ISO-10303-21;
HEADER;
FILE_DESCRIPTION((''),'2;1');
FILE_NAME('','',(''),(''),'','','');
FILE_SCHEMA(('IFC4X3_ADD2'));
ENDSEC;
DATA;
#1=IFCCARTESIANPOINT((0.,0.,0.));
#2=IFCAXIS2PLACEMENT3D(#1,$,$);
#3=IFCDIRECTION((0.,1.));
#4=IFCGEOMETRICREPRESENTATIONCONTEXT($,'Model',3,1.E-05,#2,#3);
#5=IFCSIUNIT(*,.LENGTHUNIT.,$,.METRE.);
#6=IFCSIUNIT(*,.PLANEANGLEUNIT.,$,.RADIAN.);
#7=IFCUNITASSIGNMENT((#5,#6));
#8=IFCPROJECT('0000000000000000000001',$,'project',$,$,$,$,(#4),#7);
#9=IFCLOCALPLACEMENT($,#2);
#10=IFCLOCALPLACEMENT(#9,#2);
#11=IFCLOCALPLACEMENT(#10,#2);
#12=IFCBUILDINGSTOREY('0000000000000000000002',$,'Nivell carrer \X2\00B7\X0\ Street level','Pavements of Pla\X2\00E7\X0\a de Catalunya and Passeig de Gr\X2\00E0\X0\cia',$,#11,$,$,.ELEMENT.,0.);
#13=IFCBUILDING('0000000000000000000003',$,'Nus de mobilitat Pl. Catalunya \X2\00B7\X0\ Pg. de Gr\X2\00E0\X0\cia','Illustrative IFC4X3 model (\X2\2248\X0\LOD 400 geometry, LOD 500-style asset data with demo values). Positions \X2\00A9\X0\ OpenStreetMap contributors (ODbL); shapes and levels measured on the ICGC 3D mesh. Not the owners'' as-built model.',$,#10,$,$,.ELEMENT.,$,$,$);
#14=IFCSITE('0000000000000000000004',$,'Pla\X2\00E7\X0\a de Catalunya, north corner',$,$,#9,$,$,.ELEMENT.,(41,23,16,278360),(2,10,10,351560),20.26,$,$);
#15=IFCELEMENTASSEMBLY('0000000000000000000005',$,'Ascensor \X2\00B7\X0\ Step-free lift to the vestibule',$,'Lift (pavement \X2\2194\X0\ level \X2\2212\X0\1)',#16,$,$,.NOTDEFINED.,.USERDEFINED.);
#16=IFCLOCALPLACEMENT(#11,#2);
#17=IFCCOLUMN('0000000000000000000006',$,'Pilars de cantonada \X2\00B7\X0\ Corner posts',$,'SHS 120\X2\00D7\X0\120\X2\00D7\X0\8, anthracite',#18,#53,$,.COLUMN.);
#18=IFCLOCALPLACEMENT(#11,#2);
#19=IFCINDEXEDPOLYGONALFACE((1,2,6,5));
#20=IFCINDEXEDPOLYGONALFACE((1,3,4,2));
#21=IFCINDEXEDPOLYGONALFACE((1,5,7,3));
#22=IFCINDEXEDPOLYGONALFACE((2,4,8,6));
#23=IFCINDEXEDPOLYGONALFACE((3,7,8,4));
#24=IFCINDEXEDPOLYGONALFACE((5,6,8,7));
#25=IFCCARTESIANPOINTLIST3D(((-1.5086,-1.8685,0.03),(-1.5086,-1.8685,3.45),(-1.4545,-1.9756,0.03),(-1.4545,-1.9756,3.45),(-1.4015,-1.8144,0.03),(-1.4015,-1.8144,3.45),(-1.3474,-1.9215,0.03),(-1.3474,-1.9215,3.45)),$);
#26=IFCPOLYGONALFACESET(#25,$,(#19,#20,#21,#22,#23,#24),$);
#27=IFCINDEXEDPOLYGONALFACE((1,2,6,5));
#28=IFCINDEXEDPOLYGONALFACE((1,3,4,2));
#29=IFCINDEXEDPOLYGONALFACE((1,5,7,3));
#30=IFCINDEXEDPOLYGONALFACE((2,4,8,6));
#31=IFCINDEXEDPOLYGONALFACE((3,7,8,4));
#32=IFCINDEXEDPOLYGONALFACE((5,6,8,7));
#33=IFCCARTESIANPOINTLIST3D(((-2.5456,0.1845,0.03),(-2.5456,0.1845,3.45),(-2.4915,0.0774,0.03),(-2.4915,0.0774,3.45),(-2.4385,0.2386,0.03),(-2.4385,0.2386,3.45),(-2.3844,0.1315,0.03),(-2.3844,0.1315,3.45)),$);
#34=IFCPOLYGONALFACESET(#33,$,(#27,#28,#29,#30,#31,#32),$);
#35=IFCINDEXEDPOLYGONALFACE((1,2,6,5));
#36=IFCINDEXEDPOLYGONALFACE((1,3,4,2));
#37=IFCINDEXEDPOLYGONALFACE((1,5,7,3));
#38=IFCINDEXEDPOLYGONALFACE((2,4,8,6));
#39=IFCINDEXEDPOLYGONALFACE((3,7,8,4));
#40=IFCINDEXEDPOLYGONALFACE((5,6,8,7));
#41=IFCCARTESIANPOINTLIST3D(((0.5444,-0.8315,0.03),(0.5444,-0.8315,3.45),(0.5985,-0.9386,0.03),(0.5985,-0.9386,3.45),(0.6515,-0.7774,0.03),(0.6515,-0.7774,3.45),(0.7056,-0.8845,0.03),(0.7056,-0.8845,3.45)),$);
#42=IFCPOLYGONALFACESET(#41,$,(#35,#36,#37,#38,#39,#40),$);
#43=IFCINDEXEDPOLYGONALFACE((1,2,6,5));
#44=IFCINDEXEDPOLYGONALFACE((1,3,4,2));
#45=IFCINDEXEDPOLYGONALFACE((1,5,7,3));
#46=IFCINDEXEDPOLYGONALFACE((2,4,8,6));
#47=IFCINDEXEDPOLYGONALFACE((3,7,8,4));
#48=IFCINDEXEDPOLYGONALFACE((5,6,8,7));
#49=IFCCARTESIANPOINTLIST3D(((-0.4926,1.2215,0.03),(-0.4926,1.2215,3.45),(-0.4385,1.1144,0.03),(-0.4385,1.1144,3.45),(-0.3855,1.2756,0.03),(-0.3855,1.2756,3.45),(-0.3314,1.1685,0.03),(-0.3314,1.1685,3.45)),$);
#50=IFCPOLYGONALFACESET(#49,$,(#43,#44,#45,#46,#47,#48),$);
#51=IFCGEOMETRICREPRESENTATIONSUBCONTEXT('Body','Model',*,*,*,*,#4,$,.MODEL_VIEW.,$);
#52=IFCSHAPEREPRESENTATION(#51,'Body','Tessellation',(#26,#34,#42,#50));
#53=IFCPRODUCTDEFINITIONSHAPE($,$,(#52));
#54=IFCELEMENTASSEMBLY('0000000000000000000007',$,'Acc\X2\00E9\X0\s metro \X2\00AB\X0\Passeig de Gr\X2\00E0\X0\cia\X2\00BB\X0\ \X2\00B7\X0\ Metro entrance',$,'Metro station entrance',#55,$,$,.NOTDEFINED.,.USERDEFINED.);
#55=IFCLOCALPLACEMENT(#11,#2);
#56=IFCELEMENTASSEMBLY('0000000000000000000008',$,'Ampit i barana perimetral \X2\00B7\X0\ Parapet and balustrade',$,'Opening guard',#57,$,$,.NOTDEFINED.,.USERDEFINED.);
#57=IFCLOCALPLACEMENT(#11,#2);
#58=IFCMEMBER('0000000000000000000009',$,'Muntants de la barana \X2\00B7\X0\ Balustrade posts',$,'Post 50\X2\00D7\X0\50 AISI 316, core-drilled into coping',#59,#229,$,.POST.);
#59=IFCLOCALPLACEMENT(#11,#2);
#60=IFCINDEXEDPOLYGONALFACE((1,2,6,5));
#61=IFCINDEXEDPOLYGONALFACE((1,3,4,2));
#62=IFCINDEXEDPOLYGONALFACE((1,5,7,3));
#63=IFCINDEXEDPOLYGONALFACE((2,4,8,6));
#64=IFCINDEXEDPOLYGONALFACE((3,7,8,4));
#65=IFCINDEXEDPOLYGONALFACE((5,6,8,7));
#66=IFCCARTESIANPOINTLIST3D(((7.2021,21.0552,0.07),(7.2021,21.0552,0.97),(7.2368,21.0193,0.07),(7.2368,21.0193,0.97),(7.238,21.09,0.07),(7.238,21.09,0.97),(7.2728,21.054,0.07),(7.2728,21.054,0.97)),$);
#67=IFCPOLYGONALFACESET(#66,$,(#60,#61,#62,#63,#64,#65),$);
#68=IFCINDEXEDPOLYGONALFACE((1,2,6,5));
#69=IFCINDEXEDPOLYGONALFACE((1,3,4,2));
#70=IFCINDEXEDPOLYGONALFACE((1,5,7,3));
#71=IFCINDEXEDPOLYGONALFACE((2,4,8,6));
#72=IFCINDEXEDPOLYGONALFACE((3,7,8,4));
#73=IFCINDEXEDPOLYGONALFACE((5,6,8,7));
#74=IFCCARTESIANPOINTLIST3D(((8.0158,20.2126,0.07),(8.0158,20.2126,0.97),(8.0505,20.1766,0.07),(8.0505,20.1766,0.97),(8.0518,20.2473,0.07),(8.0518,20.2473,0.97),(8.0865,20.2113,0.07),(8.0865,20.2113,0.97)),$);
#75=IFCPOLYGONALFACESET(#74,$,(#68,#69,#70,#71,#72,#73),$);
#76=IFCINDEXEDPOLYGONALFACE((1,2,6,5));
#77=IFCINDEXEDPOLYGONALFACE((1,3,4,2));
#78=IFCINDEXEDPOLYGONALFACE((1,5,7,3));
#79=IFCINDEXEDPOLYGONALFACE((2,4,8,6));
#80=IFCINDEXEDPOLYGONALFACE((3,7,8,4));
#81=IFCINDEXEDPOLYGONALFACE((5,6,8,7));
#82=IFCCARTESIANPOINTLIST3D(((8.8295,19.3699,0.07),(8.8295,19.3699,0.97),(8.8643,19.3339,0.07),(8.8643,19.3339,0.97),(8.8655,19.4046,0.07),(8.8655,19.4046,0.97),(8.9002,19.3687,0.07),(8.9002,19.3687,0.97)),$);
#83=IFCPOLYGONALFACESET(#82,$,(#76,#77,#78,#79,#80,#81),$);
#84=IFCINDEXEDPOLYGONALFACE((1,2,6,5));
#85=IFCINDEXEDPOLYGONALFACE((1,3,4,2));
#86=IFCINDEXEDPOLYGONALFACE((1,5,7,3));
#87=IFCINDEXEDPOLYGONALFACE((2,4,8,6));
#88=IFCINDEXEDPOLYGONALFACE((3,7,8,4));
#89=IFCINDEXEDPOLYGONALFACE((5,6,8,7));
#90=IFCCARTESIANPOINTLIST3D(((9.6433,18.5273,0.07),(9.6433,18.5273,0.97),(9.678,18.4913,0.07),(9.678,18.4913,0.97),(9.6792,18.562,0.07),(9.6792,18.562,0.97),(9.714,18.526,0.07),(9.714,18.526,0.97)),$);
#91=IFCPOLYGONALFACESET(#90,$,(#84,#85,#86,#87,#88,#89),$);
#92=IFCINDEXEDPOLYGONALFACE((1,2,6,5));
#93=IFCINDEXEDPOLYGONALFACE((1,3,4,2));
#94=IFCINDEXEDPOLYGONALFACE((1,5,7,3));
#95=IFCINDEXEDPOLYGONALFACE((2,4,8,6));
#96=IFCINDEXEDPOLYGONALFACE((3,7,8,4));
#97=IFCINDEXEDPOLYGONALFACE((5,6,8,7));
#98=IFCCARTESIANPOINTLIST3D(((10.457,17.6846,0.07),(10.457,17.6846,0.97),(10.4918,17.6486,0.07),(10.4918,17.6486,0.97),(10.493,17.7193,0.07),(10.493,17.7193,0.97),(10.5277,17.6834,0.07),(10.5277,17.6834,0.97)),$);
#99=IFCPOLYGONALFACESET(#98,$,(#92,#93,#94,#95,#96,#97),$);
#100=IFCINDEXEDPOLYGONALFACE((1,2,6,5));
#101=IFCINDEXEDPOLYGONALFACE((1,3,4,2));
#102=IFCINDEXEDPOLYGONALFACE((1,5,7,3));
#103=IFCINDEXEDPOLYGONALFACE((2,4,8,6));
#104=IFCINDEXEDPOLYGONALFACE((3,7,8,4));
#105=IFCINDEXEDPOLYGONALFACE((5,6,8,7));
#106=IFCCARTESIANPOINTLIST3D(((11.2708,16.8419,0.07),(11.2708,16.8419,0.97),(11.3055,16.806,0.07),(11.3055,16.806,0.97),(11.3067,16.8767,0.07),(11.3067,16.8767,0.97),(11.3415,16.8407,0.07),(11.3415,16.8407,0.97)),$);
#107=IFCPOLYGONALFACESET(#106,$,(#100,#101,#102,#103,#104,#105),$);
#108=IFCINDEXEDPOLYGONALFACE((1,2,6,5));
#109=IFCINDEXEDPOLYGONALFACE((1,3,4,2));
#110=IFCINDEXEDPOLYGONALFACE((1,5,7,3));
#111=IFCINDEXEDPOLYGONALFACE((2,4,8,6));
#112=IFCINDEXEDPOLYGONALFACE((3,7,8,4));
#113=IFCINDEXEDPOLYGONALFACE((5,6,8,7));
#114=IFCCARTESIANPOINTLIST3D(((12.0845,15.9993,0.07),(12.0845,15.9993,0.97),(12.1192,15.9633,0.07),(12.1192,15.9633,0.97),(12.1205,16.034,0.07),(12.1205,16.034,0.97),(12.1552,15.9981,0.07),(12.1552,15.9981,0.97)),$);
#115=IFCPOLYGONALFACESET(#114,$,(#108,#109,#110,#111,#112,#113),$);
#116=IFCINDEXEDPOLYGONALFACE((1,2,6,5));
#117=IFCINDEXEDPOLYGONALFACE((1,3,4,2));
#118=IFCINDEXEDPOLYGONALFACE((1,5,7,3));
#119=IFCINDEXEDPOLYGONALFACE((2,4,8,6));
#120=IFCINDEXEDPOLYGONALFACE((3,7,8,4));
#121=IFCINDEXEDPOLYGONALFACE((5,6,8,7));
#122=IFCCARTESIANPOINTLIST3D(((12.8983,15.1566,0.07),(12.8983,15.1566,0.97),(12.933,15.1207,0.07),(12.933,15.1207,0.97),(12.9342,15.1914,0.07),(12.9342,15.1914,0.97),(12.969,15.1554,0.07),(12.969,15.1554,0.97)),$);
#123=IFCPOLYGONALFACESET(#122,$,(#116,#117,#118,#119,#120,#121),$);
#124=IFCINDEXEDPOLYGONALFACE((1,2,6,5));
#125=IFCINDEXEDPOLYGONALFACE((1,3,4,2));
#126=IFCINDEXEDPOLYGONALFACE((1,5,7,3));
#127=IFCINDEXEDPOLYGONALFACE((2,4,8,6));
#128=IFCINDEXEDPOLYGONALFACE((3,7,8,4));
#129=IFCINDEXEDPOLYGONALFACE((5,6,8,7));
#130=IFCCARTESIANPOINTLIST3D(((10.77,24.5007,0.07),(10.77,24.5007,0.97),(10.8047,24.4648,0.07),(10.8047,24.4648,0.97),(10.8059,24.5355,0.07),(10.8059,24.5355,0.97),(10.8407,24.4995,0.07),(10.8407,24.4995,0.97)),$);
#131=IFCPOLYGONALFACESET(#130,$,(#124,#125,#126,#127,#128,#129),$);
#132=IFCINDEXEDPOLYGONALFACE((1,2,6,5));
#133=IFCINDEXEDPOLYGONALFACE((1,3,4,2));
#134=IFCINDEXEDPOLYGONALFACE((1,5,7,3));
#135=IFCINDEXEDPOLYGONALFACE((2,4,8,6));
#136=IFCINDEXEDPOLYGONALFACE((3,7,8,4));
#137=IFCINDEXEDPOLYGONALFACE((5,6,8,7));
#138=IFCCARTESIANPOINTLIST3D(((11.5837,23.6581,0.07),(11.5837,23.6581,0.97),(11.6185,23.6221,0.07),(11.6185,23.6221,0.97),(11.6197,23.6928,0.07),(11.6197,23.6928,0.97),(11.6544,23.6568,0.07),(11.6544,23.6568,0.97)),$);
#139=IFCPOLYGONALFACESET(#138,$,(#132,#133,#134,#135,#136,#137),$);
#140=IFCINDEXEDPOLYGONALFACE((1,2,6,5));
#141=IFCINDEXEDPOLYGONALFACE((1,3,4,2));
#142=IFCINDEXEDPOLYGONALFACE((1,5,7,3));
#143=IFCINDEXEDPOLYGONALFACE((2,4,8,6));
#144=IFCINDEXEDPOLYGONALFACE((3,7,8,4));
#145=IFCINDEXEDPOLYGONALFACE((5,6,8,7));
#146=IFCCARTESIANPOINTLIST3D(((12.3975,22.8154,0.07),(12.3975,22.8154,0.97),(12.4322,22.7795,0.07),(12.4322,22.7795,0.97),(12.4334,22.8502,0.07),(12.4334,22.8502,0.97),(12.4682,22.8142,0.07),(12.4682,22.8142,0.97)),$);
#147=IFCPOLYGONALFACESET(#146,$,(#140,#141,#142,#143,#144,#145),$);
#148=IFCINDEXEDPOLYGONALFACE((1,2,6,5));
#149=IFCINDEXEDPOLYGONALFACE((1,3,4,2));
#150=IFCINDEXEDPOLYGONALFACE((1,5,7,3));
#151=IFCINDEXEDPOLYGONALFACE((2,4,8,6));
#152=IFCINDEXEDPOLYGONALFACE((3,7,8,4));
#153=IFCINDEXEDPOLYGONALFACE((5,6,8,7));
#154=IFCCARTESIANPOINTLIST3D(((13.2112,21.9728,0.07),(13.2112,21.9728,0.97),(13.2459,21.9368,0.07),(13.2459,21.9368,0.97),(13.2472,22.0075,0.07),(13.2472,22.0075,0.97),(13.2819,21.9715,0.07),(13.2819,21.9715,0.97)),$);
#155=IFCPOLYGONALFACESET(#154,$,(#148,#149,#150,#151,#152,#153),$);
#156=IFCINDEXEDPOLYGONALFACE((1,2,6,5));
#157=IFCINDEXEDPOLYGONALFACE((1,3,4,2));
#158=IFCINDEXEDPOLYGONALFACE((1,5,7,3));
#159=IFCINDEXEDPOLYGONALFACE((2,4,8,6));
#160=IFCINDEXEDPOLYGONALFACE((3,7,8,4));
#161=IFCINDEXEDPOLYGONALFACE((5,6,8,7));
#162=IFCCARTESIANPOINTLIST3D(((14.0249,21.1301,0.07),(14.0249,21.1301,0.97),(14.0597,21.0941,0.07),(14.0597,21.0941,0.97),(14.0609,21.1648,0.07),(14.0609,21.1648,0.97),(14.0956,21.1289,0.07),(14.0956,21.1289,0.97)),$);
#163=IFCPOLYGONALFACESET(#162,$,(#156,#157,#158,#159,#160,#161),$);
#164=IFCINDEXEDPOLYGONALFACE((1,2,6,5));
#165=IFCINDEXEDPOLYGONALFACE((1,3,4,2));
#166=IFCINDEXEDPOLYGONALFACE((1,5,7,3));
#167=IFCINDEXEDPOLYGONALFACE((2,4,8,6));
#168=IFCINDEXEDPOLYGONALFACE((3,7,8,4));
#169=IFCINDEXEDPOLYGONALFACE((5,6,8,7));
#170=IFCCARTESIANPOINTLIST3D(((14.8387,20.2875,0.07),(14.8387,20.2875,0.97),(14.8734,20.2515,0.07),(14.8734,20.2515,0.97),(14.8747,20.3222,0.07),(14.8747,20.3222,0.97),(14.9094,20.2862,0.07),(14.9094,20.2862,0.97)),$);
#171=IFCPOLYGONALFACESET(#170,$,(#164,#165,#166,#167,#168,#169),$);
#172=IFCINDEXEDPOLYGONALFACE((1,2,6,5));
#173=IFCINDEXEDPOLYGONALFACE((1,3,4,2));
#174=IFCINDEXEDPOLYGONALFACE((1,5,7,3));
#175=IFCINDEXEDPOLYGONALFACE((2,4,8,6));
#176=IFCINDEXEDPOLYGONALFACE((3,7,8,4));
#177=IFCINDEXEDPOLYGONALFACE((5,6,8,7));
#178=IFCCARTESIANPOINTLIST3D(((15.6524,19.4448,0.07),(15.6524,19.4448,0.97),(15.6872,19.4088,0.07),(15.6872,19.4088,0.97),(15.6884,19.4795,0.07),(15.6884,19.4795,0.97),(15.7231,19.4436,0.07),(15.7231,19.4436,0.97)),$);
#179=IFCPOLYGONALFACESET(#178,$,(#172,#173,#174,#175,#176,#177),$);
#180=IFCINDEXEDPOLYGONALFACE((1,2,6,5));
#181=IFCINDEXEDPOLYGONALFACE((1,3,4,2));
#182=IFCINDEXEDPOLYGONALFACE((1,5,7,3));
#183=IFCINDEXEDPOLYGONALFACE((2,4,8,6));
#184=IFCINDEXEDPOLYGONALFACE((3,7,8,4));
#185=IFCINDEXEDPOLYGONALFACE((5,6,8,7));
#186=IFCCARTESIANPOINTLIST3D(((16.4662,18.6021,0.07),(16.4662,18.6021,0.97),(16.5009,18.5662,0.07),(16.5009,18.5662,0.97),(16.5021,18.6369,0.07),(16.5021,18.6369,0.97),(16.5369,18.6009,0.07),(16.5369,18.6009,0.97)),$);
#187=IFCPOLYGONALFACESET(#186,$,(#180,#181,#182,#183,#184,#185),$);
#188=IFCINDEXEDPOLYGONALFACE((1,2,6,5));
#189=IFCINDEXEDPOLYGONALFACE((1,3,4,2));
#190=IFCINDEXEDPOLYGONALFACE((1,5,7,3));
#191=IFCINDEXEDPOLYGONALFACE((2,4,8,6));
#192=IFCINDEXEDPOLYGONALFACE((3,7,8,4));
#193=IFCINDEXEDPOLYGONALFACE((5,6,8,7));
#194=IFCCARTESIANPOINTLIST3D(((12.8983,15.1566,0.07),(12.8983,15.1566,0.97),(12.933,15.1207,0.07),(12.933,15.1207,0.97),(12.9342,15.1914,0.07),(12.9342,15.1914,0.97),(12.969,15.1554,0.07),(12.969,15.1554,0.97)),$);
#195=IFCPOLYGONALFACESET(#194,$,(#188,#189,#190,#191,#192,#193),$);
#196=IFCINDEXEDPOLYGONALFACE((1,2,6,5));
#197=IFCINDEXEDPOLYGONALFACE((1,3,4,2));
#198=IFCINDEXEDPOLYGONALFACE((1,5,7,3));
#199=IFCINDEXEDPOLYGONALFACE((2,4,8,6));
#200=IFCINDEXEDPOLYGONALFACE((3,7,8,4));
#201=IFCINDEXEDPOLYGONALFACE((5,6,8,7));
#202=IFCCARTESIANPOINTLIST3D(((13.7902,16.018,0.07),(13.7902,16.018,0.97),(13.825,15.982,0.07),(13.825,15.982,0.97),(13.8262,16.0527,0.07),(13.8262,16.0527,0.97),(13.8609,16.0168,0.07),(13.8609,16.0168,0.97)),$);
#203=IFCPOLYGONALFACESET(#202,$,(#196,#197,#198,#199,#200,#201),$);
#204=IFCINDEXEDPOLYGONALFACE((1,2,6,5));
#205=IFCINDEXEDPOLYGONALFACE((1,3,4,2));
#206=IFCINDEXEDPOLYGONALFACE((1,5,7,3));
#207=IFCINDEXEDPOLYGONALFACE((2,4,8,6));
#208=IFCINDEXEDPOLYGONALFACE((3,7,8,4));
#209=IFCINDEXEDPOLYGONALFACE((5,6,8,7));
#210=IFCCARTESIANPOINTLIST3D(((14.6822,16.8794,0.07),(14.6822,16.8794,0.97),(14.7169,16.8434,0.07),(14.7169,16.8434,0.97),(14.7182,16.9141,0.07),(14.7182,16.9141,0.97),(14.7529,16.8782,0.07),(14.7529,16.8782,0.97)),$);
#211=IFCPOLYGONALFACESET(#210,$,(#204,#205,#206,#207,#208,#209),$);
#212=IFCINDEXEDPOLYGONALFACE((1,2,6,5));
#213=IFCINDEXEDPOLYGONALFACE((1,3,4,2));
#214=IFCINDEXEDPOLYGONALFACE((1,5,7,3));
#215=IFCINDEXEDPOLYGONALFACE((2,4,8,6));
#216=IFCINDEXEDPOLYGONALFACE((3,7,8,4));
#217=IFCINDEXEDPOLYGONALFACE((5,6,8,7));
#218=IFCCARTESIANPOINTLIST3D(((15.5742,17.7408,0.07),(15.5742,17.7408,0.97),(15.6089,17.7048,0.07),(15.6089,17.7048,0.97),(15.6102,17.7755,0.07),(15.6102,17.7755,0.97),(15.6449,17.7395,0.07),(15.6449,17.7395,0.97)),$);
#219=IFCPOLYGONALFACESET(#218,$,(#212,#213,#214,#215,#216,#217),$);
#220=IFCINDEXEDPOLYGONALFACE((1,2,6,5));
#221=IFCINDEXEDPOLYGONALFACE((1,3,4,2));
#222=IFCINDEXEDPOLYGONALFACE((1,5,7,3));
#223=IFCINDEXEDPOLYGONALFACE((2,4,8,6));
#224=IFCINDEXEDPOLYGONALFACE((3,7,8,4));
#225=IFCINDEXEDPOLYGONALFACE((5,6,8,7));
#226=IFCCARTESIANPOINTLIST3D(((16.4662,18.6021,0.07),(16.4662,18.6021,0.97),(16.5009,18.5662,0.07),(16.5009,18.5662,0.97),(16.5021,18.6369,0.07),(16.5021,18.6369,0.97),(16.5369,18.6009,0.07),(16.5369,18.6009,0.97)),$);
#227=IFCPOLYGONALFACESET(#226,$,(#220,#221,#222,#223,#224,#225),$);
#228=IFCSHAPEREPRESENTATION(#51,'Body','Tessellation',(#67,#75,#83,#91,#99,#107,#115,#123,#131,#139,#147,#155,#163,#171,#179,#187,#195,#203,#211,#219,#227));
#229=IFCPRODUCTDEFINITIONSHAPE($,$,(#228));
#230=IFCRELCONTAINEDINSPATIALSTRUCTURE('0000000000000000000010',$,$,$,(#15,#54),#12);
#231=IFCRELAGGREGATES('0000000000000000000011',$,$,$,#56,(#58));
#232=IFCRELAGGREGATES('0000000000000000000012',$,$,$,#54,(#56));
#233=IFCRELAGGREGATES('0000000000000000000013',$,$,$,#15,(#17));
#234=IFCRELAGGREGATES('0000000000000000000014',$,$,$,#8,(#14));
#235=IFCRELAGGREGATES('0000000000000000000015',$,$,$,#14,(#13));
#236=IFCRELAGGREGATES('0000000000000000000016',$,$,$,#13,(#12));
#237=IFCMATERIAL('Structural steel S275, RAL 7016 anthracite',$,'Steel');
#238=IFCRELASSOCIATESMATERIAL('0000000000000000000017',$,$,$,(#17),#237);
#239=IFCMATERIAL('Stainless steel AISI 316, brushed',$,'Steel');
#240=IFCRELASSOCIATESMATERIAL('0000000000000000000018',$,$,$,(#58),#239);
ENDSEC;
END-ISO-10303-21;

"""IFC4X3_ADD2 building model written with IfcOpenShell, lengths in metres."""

from ifc_helpers import new_model, si_unit, direction, frame, frame_2d, origin, place, context, subcontext, project, spatial, rectangle, extrude, material, element, aggregate, save


model = new_model("IFC4X3_ADD2")

# Units and contexts
model_context = context("Model", 3, precision=1e-05, world=origin(), true_north=direction((0.0, 1.0)))
body_context = subcontext(model_context, "Body", "Model", "MODEL_VIEW")
ifc_project = project(units=[si_unit("LENGTHUNIT", "METRE"), si_unit("PLANEANGLEUNIT", "RADIAN")], contexts=[model_context])

# Site, building, storey
site_placement = place(None, origin())
site = spatial("IfcSite", under=ifc_project, at=site_placement, Name="Plaça de Catalunya, north corner", CompositionType="ELEMENT", RefLatitude=(41, 23, 16, 278360), RefLongitude=(2, 10, 10, 351560), RefElevation=20.26)
building_placement = place(site_placement, origin())
building = spatial("IfcBuilding", under=site, at=building_placement, Name="Nus de mobilitat Pl. Catalunya · Pg. de Gràcia", Description="Illustrative IFC4X3 model (≈LOD 400 geometry, LOD 500-style asset data with demo values). Positions © OpenStreetMap contributors (ODbL); shapes and levels measured on the ICGC 3D mesh. Not the owners' as-built model.", CompositionType="ELEMENT")
storey_placement = place(building_placement, origin())
storey = spatial("IfcBuildingStorey", under=building, at=storey_placement, Name="Nivell carrer · Street level", Description="Pavements of Plaça de Catalunya and Passeig de Gràcia", CompositionType="ELEMENT", Elevation=0.0)

# Element assembly, column
assembly_1_placement = place(building_placement, origin())
assembly_1 = element("IfcElementAssembly", 1, at=assembly_1_placement, inside=storey, Name="Ascensor · Step-free lift to the vestibule", ObjectType="Lift (pavement ↔ level −1)", AssemblyPlace="NOTDEFINED", PredefinedType="USERDEFINED")
ifc_material_1 = material(Name="Structural steel S275, RAL 7016 anthracite", Category="Steel")
column_placement = place(building_placement, origin())
column = element("IfcColumn", 2, at=column_placement, material=ifc_material_1, Name="Pilars de cantonada · Corner posts", ObjectType="SHS 120×120×8, anthracite", PredefinedType="COLUMN", context=body_context, shape_type="SweptSolid", body=[
    extrude(rectangle(XDim=0.12, YDim=0.12, at=frame_2d((0.0, 0.0), x_axis=(0.892586, 0.450878))), frame((-1.428, -1.895, 0.03)), (0.0, 0.0, 1.0), 3.42),
    extrude(rectangle(XDim=0.12, YDim=0.12, at=frame_2d((0.0, 0.0), x_axis=(0.892586, 0.450878))), frame((-2.465, 0.158, 0.03)), (0.0, 0.0, 1.0), 3.42),
    extrude(rectangle(XDim=0.12, YDim=0.12, at=frame_2d((0.0, 0.0), x_axis=(0.892586, 0.450878))), frame((0.625, -0.858, 0.03)), (0.0, 0.0, 1.0), 3.42),
    extrude(rectangle(XDim=0.12, YDim=0.12, at=frame_2d((0.0, 0.0), x_axis=(0.892586, 0.450878))), frame((-0.412, 1.195, 0.03)), (0.0, 0.0, 1.0), 3.42),
])

# Element assemblies, member
assembly_2_placement = place(building_placement, origin())
assembly_2 = element("IfcElementAssembly", 3, at=assembly_2_placement, inside=storey, Name="Accés metro «Passeig de Gràcia» · Metro entrance", ObjectType="Metro station entrance", AssemblyPlace="NOTDEFINED", PredefinedType="USERDEFINED")
assembly_3_placement = place(building_placement, origin())
assembly_3 = element("IfcElementAssembly", 4, at=assembly_3_placement, Name="Ampit i barana perimetral · Parapet and balustrade", ObjectType="Opening guard", AssemblyPlace="NOTDEFINED", PredefinedType="USERDEFINED")
ifc_material_2 = material(Name="Stainless steel AISI 316, brushed", Category="Steel")
member_1_placement = place(building_placement, origin())
member_1 = element("IfcMember", 5, at=member_1_placement, material=ifc_material_2, Name="Muntants de la barana · Balustrade posts", ObjectType="Post 50×50 AISI 316, core-drilled into coping", PredefinedType="POST", context=body_context, shape_type="SweptSolid", body=[
    extrude(rectangle(XDim=0.05, YDim=0.05, at=frame_2d((0.0, 0.0), x_axis=(0.694658, -0.71934))), frame((7.2374, 21.0546, 0.07)), (0.0, 0.0, 1.0), 0.9),
    extrude(rectangle(XDim=0.05, YDim=0.05, at=frame_2d((0.0, 0.0), x_axis=(0.694658, -0.71934))), frame((8.0511, 20.212, 0.07)), (0.0, 0.0, 1.0), 0.9),
    extrude(rectangle(XDim=0.05, YDim=0.05, at=frame_2d((0.0, 0.0), x_axis=(0.694658, -0.71934))), frame((8.8649, 19.3693, 0.07)), (0.0, 0.0, 1.0), 0.9),
    extrude(rectangle(XDim=0.05, YDim=0.05, at=frame_2d((0.0, 0.0), x_axis=(0.694658, -0.71934))), frame((9.6786, 18.5266, 0.07)), (0.0, 0.0, 1.0), 0.9),
    extrude(rectangle(XDim=0.05, YDim=0.05, at=frame_2d((0.0, 0.0), x_axis=(0.694658, -0.71934))), frame((10.4924, 17.684, 0.07)), (0.0, 0.0, 1.0), 0.9),
    extrude(rectangle(XDim=0.05, YDim=0.05, at=frame_2d((0.0, 0.0), x_axis=(0.694658, -0.71934))), frame((11.3061, 16.8413, 0.07)), (0.0, 0.0, 1.0), 0.9),
    extrude(rectangle(XDim=0.05, YDim=0.05, at=frame_2d((0.0, 0.0), x_axis=(0.694658, -0.71934))), frame((12.1199, 15.9987, 0.07)), (0.0, 0.0, 1.0), 0.9),
    extrude(rectangle(XDim=0.05, YDim=0.05, at=frame_2d((0.0, 0.0), x_axis=(0.694658, -0.71934))), frame((12.9336, 15.156, 0.07)), (0.0, 0.0, 1.0), 0.9),
    extrude(rectangle(XDim=0.05, YDim=0.05, at=frame_2d((0.0, 0.0), x_axis=(0.694658, -0.71934))), frame((10.8053, 24.5001, 0.07)), (0.0, 0.0, 1.0), 0.9),
    extrude(rectangle(XDim=0.05, YDim=0.05, at=frame_2d((0.0, 0.0), x_axis=(0.694658, -0.71934))), frame((11.6191, 23.6575, 0.07)), (0.0, 0.0, 1.0), 0.9),
    extrude(rectangle(XDim=0.05, YDim=0.05, at=frame_2d((0.0, 0.0), x_axis=(0.694658, -0.71934))), frame((12.4328, 22.8148, 0.07)), (0.0, 0.0, 1.0), 0.9),
    extrude(rectangle(XDim=0.05, YDim=0.05, at=frame_2d((0.0, 0.0), x_axis=(0.694658, -0.71934))), frame((13.2466, 21.9721, 0.07)), (0.0, 0.0, 1.0), 0.9),
    extrude(rectangle(XDim=0.05, YDim=0.05, at=frame_2d((0.0, 0.0), x_axis=(0.694658, -0.71934))), frame((14.0603, 21.1295, 0.07)), (0.0, 0.0, 1.0), 0.9),
    extrude(rectangle(XDim=0.05, YDim=0.05, at=frame_2d((0.0, 0.0), x_axis=(0.694658, -0.71934))), frame((14.874, 20.2868, 0.07)), (0.0, 0.0, 1.0), 0.9),
    extrude(rectangle(XDim=0.05, YDim=0.05, at=frame_2d((0.0, 0.0), x_axis=(0.694658, -0.71934))), frame((15.6878, 19.4442, 0.07)), (0.0, 0.0, 1.0), 0.9),
    extrude(rectangle(XDim=0.05, YDim=0.05, at=frame_2d((0.0, 0.0), x_axis=(0.694658, -0.71934))), frame((16.5015, 18.6015, 0.07)), (0.0, 0.0, 1.0), 0.9),
    extrude(rectangle(XDim=0.05, YDim=0.05, at=frame_2d((0.0, 0.0), x_axis=(0.694658, -0.71934))), frame((12.9336, 15.156, 0.07)), (0.0, 0.0, 1.0), 0.9),
    extrude(rectangle(XDim=0.05, YDim=0.05, at=frame_2d((0.0, 0.0), x_axis=(0.694658, -0.71934))), frame((13.8256, 16.0174, 0.07)), (0.0, 0.0, 1.0), 0.9),
    extrude(rectangle(XDim=0.05, YDim=0.05, at=frame_2d((0.0, 0.0), x_axis=(0.694658, -0.71934))), frame((14.7176, 16.8788, 0.07)), (0.0, 0.0, 1.0), 0.9),
    extrude(rectangle(XDim=0.05, YDim=0.05, at=frame_2d((0.0, 0.0), x_axis=(0.694658, -0.71934))), frame((15.6095, 17.7401, 0.07)), (0.0, 0.0, 1.0), 0.9),
    extrude(rectangle(XDim=0.05, YDim=0.05, at=frame_2d((0.0, 0.0), x_axis=(0.694658, -0.71934))), frame((16.5015, 18.6015, 0.07)), (0.0, 0.0, 1.0), 0.9),
])

aggregate(assembly_3, [member_1])

aggregate(assembly_2, [assembly_3])

aggregate(assembly_1, [column])

save(model, "model.ifc")
